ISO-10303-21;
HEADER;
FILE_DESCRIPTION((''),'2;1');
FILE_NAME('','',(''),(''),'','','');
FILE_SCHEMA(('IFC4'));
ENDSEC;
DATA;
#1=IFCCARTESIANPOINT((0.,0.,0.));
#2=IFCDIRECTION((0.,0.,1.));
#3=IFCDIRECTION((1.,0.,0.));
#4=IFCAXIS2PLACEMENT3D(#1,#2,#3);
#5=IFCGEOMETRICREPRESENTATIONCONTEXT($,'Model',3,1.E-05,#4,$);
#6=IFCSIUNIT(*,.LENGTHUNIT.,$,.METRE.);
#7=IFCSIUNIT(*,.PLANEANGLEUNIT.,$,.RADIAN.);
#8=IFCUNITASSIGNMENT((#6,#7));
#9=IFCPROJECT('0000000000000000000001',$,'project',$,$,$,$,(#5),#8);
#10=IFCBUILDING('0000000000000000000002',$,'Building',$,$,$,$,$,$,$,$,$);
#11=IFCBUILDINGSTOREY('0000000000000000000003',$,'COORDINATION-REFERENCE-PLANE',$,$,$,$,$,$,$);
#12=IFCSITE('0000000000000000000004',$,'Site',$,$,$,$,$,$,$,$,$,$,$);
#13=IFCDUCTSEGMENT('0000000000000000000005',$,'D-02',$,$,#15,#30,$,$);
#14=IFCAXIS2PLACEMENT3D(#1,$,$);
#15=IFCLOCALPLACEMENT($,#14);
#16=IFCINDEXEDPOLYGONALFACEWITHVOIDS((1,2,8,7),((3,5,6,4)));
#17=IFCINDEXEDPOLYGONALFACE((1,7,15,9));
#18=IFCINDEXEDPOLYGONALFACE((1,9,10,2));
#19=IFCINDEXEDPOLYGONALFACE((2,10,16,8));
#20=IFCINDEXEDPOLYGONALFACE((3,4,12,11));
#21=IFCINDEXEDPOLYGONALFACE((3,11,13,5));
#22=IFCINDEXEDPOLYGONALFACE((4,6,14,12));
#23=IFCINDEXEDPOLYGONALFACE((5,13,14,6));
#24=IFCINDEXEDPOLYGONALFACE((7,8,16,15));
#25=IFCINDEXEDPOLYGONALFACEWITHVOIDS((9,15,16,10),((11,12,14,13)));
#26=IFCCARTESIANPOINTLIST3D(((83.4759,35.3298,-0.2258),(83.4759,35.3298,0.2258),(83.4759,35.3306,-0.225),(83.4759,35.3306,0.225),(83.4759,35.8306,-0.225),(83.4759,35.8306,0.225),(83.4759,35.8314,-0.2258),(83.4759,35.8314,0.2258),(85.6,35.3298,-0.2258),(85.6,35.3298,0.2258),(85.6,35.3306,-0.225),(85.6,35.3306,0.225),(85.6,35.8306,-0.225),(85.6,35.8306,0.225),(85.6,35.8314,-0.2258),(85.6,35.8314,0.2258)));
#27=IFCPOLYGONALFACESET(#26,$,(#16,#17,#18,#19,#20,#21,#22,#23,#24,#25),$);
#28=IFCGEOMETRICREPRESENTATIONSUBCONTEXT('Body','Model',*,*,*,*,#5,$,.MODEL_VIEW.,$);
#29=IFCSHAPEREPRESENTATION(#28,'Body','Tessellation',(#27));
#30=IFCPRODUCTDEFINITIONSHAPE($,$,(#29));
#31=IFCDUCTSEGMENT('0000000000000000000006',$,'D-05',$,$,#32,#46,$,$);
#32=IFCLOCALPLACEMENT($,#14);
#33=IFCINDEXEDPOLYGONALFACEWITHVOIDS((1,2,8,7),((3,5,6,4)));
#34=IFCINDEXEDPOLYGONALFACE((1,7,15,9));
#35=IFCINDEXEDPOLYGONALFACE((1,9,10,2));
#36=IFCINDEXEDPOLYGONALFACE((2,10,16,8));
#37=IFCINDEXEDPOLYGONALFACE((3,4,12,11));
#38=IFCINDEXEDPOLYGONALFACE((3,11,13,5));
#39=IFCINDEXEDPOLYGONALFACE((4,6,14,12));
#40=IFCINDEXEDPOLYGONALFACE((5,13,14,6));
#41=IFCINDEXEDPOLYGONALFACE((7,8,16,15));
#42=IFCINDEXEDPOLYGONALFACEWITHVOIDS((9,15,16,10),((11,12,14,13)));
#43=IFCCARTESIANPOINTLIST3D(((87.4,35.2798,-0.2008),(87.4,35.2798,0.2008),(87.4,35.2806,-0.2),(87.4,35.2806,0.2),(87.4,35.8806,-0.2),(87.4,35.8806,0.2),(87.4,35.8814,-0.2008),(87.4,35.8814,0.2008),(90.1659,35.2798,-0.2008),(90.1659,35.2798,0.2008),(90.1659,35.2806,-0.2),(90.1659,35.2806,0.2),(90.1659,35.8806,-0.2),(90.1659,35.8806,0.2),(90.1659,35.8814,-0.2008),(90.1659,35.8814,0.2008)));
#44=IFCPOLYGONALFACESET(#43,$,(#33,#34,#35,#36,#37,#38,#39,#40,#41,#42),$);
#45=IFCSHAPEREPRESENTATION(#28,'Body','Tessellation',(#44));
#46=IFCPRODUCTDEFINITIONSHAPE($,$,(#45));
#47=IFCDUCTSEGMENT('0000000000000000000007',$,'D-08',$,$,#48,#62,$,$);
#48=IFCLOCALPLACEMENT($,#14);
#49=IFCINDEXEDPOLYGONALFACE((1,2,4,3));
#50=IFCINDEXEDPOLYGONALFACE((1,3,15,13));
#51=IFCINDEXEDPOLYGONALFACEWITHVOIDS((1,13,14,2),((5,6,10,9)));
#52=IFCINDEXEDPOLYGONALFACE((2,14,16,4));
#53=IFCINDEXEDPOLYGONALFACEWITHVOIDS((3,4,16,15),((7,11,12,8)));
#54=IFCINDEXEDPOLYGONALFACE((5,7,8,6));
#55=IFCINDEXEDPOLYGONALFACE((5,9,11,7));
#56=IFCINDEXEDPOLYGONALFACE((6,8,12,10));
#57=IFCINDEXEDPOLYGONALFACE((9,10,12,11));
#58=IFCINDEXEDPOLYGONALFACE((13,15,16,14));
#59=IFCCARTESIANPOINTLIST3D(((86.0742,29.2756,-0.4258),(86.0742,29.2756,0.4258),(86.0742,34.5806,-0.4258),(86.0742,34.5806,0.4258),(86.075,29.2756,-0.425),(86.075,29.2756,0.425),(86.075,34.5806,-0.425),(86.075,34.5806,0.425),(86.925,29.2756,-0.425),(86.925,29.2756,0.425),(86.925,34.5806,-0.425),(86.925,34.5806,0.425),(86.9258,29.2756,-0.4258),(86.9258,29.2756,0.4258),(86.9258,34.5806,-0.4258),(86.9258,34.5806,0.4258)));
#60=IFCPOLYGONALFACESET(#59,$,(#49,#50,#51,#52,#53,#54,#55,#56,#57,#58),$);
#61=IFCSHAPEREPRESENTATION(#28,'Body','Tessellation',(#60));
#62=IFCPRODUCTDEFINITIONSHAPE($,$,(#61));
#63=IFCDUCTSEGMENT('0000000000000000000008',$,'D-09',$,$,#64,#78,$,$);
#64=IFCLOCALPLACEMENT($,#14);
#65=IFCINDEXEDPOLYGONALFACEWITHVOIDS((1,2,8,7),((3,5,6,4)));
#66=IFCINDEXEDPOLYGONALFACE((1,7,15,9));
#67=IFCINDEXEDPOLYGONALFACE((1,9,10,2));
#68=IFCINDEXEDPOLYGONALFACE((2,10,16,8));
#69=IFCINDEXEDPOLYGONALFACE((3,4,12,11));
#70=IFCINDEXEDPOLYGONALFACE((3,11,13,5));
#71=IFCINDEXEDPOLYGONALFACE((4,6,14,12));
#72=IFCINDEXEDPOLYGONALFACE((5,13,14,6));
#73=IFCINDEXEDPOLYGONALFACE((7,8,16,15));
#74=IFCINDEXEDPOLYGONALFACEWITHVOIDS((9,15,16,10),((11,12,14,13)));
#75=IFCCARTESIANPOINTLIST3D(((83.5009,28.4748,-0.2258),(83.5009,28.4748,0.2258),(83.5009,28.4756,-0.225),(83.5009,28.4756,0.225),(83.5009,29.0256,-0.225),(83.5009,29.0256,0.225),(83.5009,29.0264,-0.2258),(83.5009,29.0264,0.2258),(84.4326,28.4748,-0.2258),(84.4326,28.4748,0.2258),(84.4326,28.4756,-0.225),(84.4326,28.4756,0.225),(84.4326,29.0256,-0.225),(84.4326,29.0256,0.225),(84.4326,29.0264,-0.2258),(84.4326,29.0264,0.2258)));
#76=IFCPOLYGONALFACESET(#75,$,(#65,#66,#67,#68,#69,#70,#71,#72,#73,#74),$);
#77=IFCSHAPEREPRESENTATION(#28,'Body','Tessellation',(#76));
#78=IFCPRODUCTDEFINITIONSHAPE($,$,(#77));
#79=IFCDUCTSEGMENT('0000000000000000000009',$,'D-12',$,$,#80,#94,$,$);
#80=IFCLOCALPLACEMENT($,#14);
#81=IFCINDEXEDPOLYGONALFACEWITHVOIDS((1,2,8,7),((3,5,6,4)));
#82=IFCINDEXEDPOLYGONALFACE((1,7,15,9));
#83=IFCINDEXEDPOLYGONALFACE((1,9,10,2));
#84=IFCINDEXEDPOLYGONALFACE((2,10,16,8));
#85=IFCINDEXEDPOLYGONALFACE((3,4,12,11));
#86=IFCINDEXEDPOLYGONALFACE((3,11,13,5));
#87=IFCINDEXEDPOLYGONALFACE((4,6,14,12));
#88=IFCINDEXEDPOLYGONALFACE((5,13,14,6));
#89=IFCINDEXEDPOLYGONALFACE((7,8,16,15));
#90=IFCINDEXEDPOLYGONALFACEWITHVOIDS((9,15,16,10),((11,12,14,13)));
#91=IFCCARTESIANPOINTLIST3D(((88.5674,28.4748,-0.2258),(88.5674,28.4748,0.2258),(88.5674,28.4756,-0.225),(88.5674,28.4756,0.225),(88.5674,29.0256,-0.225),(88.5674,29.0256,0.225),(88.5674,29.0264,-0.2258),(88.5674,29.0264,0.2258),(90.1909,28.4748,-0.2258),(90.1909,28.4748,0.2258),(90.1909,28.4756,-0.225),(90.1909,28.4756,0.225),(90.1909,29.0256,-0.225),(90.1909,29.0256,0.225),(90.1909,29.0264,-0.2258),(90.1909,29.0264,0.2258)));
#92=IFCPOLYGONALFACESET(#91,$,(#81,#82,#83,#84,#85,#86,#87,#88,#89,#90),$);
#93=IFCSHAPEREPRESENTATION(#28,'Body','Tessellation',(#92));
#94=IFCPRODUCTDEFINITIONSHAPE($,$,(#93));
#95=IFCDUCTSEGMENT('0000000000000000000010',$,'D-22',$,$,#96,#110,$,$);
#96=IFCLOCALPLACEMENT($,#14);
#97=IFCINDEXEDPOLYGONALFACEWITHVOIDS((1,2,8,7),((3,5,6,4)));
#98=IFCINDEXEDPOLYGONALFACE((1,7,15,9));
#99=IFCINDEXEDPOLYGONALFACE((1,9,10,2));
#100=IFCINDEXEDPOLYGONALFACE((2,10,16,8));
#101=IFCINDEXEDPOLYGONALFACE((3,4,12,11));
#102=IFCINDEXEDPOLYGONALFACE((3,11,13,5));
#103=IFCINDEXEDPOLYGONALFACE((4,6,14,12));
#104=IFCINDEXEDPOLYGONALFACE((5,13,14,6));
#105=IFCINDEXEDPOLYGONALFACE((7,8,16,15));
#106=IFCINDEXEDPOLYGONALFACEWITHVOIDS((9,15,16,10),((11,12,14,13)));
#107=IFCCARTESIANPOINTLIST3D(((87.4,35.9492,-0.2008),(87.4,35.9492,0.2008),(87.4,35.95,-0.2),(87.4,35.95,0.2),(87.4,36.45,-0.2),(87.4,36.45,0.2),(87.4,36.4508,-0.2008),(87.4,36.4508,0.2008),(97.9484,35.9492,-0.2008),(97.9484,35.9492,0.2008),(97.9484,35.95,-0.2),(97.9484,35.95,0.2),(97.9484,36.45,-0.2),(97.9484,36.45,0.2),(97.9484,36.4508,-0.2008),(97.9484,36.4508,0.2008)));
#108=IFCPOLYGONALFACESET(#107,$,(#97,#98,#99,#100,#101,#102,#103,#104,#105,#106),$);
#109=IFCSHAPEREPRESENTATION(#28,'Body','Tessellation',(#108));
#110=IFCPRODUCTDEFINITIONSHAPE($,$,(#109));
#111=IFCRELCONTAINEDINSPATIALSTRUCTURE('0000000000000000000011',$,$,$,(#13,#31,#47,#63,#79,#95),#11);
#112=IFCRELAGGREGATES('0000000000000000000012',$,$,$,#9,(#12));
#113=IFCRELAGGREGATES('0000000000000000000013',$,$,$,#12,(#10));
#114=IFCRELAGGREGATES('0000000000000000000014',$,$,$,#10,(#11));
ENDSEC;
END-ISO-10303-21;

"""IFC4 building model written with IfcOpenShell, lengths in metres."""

from ifc_helpers import new_model, si_unit, frame, origin, origin_with_axes, place, context, subcontext, project, spatial, hollow_rectangle, extrude, element, save


model = new_model("IFC4")

# Units and contexts
model_context = context("Model", 3, precision=1e-05, world=origin_with_axes())
body_context_1 = subcontext(model_context, "Body", "Model", "MODEL_VIEW")
ifc_project = project(units=[si_unit("LENGTHUNIT", "METRE"), si_unit("PLANEANGLEUNIT", "RADIAN")], contexts=[model_context])

# Site, building, storey
site = spatial("IfcSite", under=ifc_project, Name="Site")
building = spatial("IfcBuilding", under=site, Name="Building")
storey = spatial("IfcBuildingStorey", under=building, Name="COORDINATION-REFERENCE-PLANE")

# Duct segments
duct_segment_1_placement = place(None, frame((83.4759, 35.5806, 0.0), z_axis=(1.0, 0.0, 0.0), x_axis=(0.0, 1.0, 0.0)))
element("IfcDuctSegment", 1, at=duct_segment_1_placement, inside=storey, Name="D-02", context=body_context_1, shape_type="SweptSolid", body=[
    extrude(hollow_rectangle(XDim=0.5016, YDim=0.4516, WallThickness=0.0008), origin(), (0.0, 0.0, 1.0), 2.1241),
])
duct_segment_2_placement = place(None, frame((87.4, 35.5806, 0.0), z_axis=(1.0, 0.0, 0.0), x_axis=(0.0, 1.0, 0.0)))
element("IfcDuctSegment", 2, at=duct_segment_2_placement, inside=storey, Name="D-05", context=body_context_1, shape_type="SweptSolid", body=[
    extrude(hollow_rectangle(XDim=0.6016, YDim=0.4016, WallThickness=0.0008), origin(), (0.0, 0.0, 1.0), 2.7659),
])
duct_segment_3_placement = place(None, frame((86.5, 29.2756, 0.0), z_axis=(0.0, 1.0, 0.0), x_axis=(1.0, 0.0, 0.0)))
element("IfcDuctSegment", 3, at=duct_segment_3_placement, inside=storey, Name="D-08", context=body_context_1, shape_type="SweptSolid", body=[
    extrude(hollow_rectangle(XDim=0.8516, YDim=0.8516, WallThickness=0.0008), origin(), (0.0, 0.0, 1.0), 5.305),
])
duct_segment_4_placement = place(None, frame((83.5009, 28.7506, 0.0), z_axis=(1.0, 0.0, 0.0), x_axis=(0.0, 1.0, 0.0)))
element("IfcDuctSegment", 4, at=duct_segment_4_placement, inside=storey, Name="D-09", context=body_context_1, shape_type="SweptSolid", body=[
    extrude(hollow_rectangle(XDim=0.5516, YDim=0.4516, WallThickness=0.0008), origin(), (0.0, 0.0, 1.0), 0.9316),
])
duct_segment_5_placement = place(None, frame((88.5674, 28.7506, 0.0), z_axis=(1.0, 0.0, 0.0), x_axis=(0.0, 1.0, 0.0)))
element("IfcDuctSegment", 5, at=duct_segment_5_placement, inside=storey, Name="D-12", context=body_context_1, shape_type="SweptSolid", body=[
    extrude(hollow_rectangle(XDim=0.5516, YDim=0.4516, WallThickness=0.0008), origin(), (0.0, 0.0, 1.0), 1.6235),
])
duct_segment_6_placement = place(None, frame((87.4, 36.2, 0.0), z_axis=(1.0, 0.0, 0.0), x_axis=(0.0, 1.0, 0.0)))
element("IfcDuctSegment", 6, at=duct_segment_6_placement, inside=storey, Name="D-22", context=body_context_1, shape_type="SweptSolid", body=[
    extrude(hollow_rectangle(XDim=0.5016, YDim=0.4016, WallThickness=0.0008), origin(), (0.0, 0.0, 1.0), 10.5484),
])

save(model, "model.ifc")
